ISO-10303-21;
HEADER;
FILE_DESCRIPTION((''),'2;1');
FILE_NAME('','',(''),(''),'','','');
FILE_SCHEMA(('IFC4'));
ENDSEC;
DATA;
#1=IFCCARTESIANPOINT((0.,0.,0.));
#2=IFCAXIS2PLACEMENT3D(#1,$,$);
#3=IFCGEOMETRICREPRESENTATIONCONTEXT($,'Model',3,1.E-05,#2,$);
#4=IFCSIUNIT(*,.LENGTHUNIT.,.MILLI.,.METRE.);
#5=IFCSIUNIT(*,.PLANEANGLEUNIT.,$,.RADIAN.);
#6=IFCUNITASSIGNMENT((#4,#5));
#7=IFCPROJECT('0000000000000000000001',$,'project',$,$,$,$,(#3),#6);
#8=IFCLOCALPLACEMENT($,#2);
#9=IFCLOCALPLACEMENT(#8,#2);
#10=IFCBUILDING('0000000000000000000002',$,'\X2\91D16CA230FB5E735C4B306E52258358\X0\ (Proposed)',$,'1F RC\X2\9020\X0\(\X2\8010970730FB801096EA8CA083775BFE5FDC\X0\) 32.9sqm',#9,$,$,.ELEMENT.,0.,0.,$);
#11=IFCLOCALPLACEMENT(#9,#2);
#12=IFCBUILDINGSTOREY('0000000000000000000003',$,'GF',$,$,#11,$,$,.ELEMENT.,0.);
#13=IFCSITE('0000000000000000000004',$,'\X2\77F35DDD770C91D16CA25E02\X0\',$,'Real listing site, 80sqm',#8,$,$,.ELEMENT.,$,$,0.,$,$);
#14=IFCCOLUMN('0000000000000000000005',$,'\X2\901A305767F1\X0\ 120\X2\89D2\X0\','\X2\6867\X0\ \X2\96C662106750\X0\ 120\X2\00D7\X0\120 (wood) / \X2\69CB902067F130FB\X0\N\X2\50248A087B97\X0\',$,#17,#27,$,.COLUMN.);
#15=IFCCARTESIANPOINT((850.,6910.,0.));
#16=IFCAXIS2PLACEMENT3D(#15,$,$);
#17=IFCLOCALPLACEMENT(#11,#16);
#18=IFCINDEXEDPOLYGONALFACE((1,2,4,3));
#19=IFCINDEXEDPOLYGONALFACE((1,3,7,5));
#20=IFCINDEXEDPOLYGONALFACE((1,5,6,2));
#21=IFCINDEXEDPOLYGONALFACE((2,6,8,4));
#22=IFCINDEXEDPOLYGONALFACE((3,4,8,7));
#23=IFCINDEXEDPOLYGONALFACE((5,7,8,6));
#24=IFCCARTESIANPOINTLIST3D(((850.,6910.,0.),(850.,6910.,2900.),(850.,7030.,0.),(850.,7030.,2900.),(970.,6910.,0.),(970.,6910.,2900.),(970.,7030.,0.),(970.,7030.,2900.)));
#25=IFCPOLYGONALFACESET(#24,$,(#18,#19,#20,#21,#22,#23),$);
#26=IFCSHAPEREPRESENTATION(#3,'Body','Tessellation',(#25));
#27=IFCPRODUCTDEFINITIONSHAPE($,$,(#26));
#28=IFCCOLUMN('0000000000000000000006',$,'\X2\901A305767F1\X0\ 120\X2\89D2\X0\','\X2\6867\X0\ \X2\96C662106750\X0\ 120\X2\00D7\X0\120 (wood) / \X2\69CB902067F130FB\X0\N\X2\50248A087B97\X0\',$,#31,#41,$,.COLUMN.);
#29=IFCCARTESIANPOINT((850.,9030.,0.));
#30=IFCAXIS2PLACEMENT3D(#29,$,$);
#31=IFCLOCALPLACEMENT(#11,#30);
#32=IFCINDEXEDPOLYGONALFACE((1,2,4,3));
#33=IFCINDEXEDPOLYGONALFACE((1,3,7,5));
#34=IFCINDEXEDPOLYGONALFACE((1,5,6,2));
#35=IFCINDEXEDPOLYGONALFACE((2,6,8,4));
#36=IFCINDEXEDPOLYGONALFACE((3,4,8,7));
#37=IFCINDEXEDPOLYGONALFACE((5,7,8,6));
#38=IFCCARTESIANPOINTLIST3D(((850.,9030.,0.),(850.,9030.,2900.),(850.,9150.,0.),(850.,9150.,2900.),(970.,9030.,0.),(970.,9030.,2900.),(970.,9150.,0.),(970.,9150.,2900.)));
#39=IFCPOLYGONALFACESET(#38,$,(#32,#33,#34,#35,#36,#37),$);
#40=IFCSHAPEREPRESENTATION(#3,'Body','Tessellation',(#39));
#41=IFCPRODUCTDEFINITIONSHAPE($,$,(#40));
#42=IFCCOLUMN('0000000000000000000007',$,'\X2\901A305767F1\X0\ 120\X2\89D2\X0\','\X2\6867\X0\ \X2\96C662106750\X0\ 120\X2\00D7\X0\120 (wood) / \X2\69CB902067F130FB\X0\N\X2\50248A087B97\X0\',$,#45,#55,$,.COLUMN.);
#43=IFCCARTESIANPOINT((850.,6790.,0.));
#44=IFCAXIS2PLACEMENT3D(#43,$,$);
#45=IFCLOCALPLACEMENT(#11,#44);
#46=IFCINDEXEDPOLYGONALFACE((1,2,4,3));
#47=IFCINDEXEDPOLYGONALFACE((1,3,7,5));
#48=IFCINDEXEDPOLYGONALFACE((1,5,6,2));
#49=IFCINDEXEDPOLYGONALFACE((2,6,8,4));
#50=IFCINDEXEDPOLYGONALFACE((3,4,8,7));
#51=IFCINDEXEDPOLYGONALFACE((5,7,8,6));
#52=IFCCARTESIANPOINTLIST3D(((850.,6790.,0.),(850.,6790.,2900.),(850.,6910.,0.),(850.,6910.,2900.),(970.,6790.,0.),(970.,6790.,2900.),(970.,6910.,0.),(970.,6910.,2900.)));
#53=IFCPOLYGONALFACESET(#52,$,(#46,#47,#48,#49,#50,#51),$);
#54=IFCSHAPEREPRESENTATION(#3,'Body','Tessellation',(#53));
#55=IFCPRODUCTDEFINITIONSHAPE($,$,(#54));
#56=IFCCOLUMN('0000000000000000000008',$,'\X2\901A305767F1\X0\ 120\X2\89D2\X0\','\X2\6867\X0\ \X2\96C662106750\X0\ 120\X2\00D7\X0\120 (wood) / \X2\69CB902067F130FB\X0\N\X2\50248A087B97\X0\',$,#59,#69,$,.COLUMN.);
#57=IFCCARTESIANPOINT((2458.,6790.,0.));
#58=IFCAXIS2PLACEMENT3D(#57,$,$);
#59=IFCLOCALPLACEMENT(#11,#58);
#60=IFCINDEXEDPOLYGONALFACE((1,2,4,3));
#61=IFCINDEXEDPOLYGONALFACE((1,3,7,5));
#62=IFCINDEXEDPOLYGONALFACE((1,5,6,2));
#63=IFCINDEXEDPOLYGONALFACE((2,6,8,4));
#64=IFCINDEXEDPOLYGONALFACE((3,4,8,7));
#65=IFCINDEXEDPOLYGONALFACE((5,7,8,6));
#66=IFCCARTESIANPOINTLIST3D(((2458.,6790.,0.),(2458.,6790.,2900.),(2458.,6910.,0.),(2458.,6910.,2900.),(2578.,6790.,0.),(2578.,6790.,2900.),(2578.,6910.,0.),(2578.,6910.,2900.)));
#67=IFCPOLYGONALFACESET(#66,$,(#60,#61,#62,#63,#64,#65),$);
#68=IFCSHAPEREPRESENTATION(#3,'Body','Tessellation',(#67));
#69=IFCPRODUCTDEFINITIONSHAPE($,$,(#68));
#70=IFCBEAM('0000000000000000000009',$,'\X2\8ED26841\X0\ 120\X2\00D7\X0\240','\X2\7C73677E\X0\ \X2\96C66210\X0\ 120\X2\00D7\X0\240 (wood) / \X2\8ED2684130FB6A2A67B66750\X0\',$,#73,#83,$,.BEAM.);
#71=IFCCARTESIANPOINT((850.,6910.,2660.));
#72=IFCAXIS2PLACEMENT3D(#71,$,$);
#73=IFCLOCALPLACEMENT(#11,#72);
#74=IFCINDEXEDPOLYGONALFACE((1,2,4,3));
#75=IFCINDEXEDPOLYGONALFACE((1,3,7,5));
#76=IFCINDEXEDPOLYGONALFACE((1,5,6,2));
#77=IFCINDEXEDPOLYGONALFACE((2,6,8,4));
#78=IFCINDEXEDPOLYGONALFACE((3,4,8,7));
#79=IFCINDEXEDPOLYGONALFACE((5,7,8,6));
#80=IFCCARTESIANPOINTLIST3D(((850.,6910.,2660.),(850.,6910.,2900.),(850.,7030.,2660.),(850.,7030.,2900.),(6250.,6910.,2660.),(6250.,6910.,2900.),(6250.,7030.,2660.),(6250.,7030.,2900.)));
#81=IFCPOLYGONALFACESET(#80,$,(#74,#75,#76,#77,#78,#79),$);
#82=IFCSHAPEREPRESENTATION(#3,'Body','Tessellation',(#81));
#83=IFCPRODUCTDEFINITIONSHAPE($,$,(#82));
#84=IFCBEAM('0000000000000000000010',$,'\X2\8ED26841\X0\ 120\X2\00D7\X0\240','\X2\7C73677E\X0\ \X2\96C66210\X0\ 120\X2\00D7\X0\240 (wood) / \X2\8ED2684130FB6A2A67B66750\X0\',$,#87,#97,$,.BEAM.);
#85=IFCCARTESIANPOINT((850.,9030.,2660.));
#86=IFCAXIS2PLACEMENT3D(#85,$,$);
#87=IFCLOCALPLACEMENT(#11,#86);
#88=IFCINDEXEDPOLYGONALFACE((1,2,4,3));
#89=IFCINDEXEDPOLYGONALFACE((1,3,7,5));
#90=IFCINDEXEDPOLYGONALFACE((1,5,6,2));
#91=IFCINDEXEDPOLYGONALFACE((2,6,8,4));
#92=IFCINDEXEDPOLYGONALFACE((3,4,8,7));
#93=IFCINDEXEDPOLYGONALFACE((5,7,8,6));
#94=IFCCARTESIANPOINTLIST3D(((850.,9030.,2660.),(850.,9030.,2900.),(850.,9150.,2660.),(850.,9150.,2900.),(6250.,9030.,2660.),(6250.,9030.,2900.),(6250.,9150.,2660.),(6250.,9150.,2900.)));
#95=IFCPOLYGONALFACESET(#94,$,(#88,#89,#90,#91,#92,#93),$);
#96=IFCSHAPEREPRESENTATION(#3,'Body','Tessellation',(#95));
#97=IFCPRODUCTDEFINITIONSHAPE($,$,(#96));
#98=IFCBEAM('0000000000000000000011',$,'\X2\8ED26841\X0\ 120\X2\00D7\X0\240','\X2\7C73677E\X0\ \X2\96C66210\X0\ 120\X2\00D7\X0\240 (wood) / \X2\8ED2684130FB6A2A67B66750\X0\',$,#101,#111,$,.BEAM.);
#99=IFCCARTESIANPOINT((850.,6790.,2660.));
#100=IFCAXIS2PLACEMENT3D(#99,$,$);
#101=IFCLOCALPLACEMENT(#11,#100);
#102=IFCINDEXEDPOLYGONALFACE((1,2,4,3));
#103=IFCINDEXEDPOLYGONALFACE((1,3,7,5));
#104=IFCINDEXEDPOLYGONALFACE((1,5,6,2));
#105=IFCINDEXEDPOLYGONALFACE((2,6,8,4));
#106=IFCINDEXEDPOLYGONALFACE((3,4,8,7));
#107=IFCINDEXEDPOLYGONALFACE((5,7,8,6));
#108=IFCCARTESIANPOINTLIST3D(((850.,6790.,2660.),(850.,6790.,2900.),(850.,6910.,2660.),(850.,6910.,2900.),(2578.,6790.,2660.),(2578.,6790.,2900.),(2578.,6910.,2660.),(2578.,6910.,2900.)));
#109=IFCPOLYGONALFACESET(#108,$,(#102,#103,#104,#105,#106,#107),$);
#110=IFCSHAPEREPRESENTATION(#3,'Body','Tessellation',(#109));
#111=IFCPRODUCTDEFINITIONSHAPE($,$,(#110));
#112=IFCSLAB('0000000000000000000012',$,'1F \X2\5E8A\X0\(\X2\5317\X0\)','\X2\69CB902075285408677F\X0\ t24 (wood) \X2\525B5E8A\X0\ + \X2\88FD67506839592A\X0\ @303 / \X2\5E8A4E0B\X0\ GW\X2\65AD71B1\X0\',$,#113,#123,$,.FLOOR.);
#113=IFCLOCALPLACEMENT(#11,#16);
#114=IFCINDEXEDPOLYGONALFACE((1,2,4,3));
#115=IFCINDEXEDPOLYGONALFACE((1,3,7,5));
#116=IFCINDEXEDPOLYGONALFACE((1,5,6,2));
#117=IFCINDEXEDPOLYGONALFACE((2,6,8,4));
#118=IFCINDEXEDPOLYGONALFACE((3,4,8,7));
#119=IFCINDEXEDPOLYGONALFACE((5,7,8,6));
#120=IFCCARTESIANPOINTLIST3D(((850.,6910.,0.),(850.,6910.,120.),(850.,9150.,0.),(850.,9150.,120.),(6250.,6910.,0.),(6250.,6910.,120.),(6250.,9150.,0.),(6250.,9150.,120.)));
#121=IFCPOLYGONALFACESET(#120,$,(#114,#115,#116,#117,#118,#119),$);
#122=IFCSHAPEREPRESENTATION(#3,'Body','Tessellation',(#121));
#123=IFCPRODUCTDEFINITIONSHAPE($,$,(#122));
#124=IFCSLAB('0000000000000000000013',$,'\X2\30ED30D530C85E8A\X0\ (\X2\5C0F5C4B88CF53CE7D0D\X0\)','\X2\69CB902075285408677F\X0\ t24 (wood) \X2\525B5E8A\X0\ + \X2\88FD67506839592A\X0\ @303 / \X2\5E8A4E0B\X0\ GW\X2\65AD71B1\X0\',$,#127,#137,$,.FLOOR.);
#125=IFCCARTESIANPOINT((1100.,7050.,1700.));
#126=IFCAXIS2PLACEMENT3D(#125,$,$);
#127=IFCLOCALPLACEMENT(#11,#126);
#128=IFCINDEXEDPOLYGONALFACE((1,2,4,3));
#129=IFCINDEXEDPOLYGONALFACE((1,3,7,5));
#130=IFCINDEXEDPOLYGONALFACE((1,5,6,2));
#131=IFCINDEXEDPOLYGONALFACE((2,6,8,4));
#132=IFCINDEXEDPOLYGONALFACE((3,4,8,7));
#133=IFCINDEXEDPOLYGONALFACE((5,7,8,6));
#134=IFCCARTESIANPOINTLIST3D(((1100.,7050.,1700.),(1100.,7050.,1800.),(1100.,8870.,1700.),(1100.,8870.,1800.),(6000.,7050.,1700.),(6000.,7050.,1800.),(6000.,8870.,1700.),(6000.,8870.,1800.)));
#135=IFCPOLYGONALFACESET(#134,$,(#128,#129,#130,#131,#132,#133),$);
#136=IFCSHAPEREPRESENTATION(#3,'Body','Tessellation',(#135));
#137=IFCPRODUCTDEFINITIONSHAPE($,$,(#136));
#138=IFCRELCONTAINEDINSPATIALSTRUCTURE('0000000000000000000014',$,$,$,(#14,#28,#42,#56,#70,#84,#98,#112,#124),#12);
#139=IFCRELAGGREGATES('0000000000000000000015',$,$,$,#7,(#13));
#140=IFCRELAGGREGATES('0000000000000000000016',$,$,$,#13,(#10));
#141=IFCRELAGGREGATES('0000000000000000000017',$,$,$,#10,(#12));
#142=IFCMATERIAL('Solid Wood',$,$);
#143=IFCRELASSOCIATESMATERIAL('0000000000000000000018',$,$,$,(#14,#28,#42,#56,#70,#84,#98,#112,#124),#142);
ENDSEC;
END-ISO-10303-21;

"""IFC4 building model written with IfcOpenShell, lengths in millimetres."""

from ifc_helpers import new_model, si_unit, frame, frame_2d, origin, place, context, project, spatial, rectangle, extrude, material, element, save


model = new_model("IFC4")

# Units and contexts
model_context = context("Model", 3, precision=1e-05, world=origin())
ifc_project = project(units=[si_unit("LENGTHUNIT", "METRE", prefix="MILLI"), si_unit("PLANEANGLEUNIT", "RADIAN")], contexts=[model_context])

# Site, building, storey
site_placement = place(None, origin())
site = spatial("IfcSite", under=ifc_project, at=site_placement, Name="石川県金沢市", ObjectType="Real listing site, 80sqm", CompositionType="ELEMENT", RefElevation=0.0)
building_placement = place(site_placement, origin())
building = spatial("IfcBuilding", under=site, at=building_placement, Name="金沢・平屋の別荘 (Proposed)", ObjectType="1F RC造(耐震・耐雪負荷対応) 32.9sqm", CompositionType="ELEMENT", ElevationOfRefHeight=0.0, ElevationOfTerrain=0.0)
storey_placement = place(building_placement, origin())
storey = spatial("IfcBuildingStorey", under=building, at=storey_placement, Name="GF", CompositionType="ELEMENT", Elevation=0.0)

# Columns
ifc_material_1 = material(Name="Solid Wood")
column_1_placement = place(storey_placement, frame((850.0, 6910.0, 0.0)))
element("IfcColumn", 1, at=column_1_placement, inside=storey, material=ifc_material_1, Name="通し柱 120角", Description="桧 集成材 120×120 (wood) / 構造柱・N値計算", PredefinedType="COLUMN", context=model_context, shape_type="SweptSolid", body=[
    extrude(rectangle(XDim=120.0, YDim=120.0, at=frame_2d((60.0, 60.0))), frame((850.0, 6910.0, 0.0)), (0.0, 0.0, 1.0), 2900.0),
])
column_2_placement = place(storey_placement, frame((850.0, 9030.0, 0.0)))
element("IfcColumn", 2, at=column_2_placement, inside=storey, material=ifc_material_1, Name="通し柱 120角", Description="桧 集成材 120×120 (wood) / 構造柱・N値計算", PredefinedType="COLUMN", context=model_context, shape_type="SweptSolid", body=[
    extrude(rectangle(XDim=120.0, YDim=120.0, at=frame_2d((60.0, 60.0))), frame((850.0, 9030.0, 0.0)), (0.0, 0.0, 1.0), 2900.0),
])
column_3_placement = place(storey_placement, frame((850.0, 6790.0, 0.0)))
element("IfcColumn", 3, at=column_3_placement, inside=storey, material=ifc_material_1, Name="通し柱 120角", Description="桧 集成材 120×120 (wood) / 構造柱・N値計算", PredefinedType="COLUMN", context=model_context, shape_type="SweptSolid", body=[
    extrude(rectangle(XDim=120.0, YDim=120.0, at=frame_2d((60.0, 60.0))), frame((850.0, 6790.0, 0.0)), (0.0, 0.0, 1.0), 2900.0),
])
column_4_placement = place(storey_placement, frame((2458.0, 6790.0, 0.0)))
element("IfcColumn", 4, at=column_4_placement, inside=storey, material=ifc_material_1, Name="通し柱 120角", Description="桧 集成材 120×120 (wood) / 構造柱・N値計算", PredefinedType="COLUMN", context=model_context, shape_type="SweptSolid", body=[
    extrude(rectangle(XDim=120.0, YDim=120.0, at=frame_2d((60.0, 60.0))), frame((2458.0, 6790.0, 0.0)), (0.0, 0.0, 1.0), 2900.0),
])

# Beams
beam_1_placement = place(storey_placement, frame((850.0, 6910.0, 2660.0)))
element("IfcBeam", 5, at=beam_1_placement, inside=storey, material=ifc_material_1, Name="軒桁 120×240", Description="米松 集成 120×240 (wood) / 軒桁・横架材", PredefinedType="BEAM", context=model_context, shape_type="SweptSolid", body=[
    extrude(rectangle(XDim=5400.0, YDim=120.0, at=frame_2d((2700.0, 60.0))), frame((850.0, 6910.0, 2660.0)), (0.0, 0.0, 1.0), 240.0),
])
beam_2_placement = place(storey_placement, frame((850.0, 9030.0, 2660.0)))
element("IfcBeam", 6, at=beam_2_placement, inside=storey, material=ifc_material_1, Name="軒桁 120×240", Description="米松 集成 120×240 (wood) / 軒桁・横架材", PredefinedType="BEAM", context=model_context, shape_type="SweptSolid", body=[
    extrude(rectangle(XDim=5400.0, YDim=120.0, at=frame_2d((2700.0, 60.0))), frame((850.0, 9030.0, 2660.0)), (0.0, 0.0, 1.0), 240.0),
])
beam_3_placement = place(storey_placement, frame((850.0, 6790.0, 2660.0)))
element("IfcBeam", 7, at=beam_3_placement, inside=storey, material=ifc_material_1, Name="軒桁 120×240", Description="米松 集成 120×240 (wood) / 軒桁・横架材", PredefinedType="BEAM", context=model_context, shape_type="SweptSolid", body=[
    extrude(rectangle(XDim=1728.0, YDim=120.0, at=frame_2d((864.0, 60.0))), frame((850.0, 6790.0, 2660.0)), (0.0, 0.0, 1.0), 240.0),
])

# Slabs
slab_1_placement = place(storey_placement, frame((850.0, 6910.0, 0.0)))
element("IfcSlab", 8, at=slab_1_placement, inside=storey, material=ifc_material_1, Name="1F 床(北)", Description="構造用合板 t24 (wood) 剛床 + 製材根太 @303 / 床下 GW断熱", PredefinedType="FLOOR", context=model_context, shape_type="SweptSolid", body=[
    extrude(rectangle(XDim=5400.0, YDim=2240.0, at=frame_2d((2700.0, 1120.0))), frame((850.0, 6910.0, 0.0)), (0.0, 0.0, 1.0), 120.0),
])
slab_2_placement = place(storey_placement, frame((1100.0, 7050.0, 1700.0)))
element("IfcSlab", 9, at=slab_2_placement, inside=storey, material=ifc_material_1, Name="ロフト床 (小屋裏収納)", Description="構造用合板 t24 (wood) 剛床 + 製材根太 @303 / 床下 GW断熱", PredefinedType="FLOOR", context=model_context, shape_type="SweptSolid", body=[
    extrude(rectangle(XDim=4900.0, YDim=1820.0, at=frame_2d((2450.0, 910.0))), frame((1100.0, 7050.0, 1700.0)), (0.0, 0.0, 1.0), 100.0),
])

save(model, "model.ifc")
